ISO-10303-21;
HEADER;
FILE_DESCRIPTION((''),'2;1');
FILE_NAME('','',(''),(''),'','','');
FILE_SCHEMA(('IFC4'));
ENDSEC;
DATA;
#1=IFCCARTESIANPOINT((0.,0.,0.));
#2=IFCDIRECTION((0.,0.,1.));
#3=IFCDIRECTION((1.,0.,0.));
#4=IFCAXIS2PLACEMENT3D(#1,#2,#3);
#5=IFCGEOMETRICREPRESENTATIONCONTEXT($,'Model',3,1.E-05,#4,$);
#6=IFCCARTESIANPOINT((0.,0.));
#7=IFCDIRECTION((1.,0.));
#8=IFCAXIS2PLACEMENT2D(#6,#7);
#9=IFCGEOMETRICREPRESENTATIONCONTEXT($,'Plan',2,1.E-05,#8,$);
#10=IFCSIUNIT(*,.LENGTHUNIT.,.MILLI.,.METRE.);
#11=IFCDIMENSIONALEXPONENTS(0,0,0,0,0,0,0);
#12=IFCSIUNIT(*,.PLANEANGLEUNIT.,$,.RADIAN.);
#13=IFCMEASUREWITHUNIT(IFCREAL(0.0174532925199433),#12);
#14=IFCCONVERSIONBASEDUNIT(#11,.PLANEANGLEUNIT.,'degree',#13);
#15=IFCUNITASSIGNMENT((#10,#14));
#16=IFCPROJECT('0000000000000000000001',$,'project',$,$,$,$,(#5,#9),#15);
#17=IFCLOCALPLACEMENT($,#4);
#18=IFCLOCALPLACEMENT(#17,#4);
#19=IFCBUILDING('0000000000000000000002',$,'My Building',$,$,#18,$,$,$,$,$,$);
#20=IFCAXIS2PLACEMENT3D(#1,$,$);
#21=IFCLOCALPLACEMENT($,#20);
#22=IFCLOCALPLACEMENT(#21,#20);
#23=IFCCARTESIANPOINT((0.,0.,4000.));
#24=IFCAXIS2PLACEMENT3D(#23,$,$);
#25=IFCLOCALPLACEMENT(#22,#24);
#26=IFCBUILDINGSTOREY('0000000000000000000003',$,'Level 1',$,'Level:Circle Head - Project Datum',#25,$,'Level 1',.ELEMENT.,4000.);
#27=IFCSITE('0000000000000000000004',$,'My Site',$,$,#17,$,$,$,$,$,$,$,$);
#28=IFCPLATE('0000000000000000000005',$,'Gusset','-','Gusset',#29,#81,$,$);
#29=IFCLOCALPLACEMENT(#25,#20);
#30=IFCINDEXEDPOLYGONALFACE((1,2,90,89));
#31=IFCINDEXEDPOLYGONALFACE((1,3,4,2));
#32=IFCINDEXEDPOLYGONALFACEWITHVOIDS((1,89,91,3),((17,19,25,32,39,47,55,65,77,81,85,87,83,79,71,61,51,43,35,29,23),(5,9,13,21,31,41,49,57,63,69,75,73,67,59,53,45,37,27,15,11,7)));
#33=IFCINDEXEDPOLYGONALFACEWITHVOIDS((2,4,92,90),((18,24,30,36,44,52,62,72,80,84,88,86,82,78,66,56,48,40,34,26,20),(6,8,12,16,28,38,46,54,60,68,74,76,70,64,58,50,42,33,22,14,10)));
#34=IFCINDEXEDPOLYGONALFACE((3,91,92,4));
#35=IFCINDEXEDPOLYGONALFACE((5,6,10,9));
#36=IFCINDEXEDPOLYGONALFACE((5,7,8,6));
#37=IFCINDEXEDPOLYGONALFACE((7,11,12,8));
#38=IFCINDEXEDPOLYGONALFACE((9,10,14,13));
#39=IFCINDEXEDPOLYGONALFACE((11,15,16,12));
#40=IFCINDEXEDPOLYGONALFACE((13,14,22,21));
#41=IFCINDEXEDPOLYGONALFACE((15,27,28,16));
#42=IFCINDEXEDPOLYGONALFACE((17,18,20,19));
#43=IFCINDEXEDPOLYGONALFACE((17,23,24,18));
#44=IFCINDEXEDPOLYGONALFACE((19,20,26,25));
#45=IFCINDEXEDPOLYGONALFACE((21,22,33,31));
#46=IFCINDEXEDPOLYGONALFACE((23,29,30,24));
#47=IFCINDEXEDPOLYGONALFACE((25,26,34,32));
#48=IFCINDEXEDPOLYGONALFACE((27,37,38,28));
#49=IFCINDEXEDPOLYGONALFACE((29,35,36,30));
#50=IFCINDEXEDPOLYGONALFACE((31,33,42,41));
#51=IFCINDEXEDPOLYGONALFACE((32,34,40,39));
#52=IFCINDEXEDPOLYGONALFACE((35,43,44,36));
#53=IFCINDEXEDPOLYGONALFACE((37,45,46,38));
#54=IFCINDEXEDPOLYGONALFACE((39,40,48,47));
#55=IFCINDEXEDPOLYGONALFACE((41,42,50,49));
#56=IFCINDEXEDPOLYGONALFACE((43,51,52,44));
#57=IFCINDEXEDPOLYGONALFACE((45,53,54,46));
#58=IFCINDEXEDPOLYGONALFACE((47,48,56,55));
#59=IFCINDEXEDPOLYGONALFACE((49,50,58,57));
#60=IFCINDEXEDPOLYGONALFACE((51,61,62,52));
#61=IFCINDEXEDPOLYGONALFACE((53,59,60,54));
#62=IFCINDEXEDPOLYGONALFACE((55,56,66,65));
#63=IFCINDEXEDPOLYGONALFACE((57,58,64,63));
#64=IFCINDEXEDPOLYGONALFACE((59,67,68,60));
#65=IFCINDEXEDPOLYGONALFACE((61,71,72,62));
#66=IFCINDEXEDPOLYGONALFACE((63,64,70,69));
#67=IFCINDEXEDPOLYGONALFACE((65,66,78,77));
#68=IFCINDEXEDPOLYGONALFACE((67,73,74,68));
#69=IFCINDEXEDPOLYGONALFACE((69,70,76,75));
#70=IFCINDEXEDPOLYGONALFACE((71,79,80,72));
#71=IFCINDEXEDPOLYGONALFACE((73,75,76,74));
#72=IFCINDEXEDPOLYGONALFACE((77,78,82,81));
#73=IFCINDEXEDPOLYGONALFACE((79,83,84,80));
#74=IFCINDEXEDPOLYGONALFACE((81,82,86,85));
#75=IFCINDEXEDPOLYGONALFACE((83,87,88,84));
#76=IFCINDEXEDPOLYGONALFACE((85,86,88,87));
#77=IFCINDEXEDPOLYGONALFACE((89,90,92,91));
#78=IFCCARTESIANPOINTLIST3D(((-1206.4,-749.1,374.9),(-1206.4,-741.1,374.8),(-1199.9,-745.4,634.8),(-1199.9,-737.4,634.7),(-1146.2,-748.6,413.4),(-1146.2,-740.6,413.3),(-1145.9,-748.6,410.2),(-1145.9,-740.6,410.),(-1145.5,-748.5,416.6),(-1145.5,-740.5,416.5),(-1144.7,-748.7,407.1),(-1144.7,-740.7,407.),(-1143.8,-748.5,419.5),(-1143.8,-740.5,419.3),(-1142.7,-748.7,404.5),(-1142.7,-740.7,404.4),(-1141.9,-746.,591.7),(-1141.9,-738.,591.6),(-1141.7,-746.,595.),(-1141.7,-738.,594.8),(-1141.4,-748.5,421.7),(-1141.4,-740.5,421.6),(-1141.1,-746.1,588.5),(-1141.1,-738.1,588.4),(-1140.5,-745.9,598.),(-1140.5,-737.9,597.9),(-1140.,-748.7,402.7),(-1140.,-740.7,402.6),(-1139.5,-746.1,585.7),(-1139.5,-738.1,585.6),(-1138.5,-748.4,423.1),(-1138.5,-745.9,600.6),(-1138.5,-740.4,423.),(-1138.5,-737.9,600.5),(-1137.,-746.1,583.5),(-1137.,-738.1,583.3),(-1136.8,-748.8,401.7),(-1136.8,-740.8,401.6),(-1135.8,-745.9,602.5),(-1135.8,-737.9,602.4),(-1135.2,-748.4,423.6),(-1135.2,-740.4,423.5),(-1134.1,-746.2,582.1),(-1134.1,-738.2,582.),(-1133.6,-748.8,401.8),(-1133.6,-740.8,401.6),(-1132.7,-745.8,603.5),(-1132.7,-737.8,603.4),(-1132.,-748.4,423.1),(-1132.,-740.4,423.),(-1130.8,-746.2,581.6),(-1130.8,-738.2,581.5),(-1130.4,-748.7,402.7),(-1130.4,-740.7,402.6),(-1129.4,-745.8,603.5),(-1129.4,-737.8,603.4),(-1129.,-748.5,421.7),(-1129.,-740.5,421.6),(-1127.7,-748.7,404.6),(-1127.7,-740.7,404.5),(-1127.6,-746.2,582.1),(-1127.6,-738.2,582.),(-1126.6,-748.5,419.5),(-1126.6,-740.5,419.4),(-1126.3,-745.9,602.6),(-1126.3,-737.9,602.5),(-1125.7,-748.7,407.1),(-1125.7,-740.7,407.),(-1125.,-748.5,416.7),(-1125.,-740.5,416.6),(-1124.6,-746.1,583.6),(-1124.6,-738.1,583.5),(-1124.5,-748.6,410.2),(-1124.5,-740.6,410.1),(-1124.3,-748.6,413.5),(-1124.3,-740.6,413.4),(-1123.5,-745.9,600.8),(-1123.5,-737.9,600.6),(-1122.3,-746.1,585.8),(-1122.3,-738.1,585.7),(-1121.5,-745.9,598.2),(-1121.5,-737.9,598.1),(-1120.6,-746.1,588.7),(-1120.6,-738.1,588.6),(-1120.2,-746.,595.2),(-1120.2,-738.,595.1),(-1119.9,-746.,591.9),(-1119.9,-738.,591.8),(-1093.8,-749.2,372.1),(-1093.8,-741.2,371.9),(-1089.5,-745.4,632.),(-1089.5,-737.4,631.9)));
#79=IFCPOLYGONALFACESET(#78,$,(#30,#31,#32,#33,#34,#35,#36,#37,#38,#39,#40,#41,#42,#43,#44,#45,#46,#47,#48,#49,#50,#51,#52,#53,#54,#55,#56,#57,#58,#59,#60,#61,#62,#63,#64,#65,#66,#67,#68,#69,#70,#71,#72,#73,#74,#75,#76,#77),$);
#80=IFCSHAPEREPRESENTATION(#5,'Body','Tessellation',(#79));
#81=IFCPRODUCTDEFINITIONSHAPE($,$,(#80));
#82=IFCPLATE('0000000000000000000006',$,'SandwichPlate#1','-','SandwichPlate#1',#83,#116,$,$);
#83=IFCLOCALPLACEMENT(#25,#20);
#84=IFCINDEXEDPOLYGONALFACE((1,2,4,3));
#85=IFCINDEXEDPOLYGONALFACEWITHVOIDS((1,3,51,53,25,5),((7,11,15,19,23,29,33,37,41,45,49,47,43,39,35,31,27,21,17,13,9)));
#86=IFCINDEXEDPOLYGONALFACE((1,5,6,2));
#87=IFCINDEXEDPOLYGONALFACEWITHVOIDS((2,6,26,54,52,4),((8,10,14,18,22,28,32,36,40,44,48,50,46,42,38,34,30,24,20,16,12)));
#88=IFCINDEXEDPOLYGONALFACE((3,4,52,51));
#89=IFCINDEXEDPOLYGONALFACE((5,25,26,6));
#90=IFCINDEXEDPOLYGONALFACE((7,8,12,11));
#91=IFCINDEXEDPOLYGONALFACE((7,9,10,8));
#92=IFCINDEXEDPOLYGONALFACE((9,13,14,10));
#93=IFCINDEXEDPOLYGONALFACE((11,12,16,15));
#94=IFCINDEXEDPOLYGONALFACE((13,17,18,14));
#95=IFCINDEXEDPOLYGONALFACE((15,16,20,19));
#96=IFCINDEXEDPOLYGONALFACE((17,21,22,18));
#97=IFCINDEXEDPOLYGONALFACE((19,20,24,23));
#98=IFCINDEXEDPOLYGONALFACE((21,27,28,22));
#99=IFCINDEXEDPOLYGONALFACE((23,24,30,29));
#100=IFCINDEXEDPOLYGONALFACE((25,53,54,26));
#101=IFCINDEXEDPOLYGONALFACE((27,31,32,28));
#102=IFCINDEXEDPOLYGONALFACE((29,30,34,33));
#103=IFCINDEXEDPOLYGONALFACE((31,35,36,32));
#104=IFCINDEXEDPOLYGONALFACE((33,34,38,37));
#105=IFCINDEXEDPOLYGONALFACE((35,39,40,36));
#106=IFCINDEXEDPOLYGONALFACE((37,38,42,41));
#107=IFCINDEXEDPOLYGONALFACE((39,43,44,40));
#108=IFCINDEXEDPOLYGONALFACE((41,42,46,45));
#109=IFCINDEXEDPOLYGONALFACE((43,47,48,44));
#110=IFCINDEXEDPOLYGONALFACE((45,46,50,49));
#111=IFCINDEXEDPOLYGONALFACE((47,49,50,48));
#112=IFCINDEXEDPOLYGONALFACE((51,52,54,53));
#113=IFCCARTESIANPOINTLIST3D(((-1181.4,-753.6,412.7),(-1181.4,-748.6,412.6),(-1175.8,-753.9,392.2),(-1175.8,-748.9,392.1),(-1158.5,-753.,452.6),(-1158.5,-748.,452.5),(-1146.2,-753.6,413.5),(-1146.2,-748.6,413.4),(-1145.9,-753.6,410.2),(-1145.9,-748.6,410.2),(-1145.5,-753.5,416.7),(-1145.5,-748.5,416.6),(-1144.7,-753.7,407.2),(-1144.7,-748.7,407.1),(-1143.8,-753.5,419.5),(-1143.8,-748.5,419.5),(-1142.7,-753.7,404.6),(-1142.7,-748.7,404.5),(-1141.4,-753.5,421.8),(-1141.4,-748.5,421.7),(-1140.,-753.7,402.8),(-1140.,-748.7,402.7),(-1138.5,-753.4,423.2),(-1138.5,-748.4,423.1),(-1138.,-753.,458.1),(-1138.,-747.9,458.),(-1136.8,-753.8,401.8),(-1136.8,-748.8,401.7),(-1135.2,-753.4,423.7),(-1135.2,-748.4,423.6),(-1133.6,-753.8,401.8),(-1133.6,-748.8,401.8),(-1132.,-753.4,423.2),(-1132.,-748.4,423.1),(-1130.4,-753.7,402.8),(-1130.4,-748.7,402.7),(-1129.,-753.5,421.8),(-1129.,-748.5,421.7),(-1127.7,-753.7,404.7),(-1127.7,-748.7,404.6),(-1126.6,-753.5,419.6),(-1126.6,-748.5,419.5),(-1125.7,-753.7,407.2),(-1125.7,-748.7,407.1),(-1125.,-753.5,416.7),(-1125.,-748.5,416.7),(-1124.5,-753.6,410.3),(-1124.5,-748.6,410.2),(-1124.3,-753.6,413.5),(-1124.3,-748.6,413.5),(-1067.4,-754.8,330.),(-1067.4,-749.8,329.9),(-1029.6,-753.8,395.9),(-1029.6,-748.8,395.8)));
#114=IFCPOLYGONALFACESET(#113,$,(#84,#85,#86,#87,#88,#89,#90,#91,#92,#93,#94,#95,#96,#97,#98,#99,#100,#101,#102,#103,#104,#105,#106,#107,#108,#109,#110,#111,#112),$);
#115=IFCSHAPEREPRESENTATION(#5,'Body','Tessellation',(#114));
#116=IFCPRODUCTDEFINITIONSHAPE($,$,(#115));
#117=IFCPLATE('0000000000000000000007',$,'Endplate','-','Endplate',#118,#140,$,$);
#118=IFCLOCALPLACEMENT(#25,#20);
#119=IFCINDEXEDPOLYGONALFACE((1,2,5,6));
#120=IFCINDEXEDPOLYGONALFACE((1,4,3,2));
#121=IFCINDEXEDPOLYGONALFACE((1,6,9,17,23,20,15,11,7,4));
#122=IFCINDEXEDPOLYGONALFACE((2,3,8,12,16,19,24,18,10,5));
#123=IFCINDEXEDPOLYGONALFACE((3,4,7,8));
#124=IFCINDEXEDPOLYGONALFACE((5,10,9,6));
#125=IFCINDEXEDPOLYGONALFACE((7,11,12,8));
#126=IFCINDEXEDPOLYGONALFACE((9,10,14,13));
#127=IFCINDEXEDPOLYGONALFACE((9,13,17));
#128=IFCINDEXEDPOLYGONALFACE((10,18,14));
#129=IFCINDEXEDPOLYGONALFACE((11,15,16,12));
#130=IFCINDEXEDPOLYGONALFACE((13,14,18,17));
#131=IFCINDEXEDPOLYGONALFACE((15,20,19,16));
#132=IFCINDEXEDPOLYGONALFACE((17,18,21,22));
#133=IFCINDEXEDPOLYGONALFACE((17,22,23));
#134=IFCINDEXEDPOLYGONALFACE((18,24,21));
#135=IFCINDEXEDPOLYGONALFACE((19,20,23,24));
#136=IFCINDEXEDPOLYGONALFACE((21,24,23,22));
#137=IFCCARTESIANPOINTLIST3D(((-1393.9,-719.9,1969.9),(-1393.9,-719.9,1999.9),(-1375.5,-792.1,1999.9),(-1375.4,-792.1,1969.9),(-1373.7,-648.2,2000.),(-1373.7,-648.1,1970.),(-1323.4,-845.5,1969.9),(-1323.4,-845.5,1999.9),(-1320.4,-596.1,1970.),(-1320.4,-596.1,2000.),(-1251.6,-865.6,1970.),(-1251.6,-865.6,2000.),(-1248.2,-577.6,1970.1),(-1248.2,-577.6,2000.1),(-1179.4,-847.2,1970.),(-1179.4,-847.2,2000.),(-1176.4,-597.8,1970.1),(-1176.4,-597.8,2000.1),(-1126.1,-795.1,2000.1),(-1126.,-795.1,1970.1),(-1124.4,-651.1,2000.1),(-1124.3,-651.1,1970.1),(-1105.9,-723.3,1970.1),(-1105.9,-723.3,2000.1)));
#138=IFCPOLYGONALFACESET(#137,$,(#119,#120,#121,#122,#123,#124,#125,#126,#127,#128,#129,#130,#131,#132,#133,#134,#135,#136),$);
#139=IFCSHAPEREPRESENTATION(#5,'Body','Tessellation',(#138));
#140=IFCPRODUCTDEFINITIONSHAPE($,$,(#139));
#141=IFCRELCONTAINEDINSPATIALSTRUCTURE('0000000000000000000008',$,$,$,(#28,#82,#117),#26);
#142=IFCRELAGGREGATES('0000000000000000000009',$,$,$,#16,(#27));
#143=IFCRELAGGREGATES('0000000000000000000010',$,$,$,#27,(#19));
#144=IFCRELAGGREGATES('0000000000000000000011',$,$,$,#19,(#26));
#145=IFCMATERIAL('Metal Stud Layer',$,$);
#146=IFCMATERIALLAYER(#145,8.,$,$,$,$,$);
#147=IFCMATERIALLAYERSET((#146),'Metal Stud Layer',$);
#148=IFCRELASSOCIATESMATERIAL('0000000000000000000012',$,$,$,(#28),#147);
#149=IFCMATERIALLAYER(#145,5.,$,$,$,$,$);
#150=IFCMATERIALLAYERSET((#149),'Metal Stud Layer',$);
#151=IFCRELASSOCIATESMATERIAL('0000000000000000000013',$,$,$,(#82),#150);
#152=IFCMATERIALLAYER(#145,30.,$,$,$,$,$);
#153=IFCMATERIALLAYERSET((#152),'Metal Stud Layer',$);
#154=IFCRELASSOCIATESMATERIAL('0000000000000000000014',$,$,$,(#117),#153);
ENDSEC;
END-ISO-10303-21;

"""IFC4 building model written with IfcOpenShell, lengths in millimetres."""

from ifc_helpers import new_model, entity, si_unit, converted_unit, point, frame, frame_2d, origin, origin_with_axes, origin_2d_with_axis, place, context, project, spatial, polyline, circle_curve, line_curve, trimmed, segment, composite_curve, circle, outline, extrude, material, layer, layer_set, element, save


model = new_model("IFC4")

# Units and contexts
model_context = context("Model", 3, precision=1e-05, world=origin_with_axes())
plan_context = context("Plan", 2, precision=1e-05, world=origin_2d_with_axis())
ifc_project = project(units=[si_unit("LENGTHUNIT", "METRE", prefix="MILLI"), converted_unit("PLANEANGLEUNIT", "degree", entity("IfcReal", 0.0174532925199433), si_unit("PLANEANGLEUNIT", "RADIAN"), dimensions=[0, 0, 0, 0, 0, 0, 0])], contexts=[model_context, plan_context])

# Site, building, storey
site_placement = place(None, origin_with_axes())
site = spatial("IfcSite", under=ifc_project, at=site_placement, Name="My Site")
building_placement = place(site_placement, origin_with_axes())
building = spatial("IfcBuilding", under=site, at=building_placement, Name="My Building")
placement_1 = place(None, origin())
placement_2 = place(placement_1, origin())
storey_placement = place(placement_2, frame((0.0, 0.0, 4000.0)))
storey = spatial("IfcBuildingStorey", under=building, at=storey_placement, Name="Level 1", ObjectType="Level:Circle Head - Project Datum", LongName="Level 1", CompositionType="ELEMENT", Elevation=4000.0)

# Plates, openings
ifc_material_1 = material(Name="Metal Stud Layer")
ifc_layer_1 = layer(ifc_material_1, 5.0)
ifc_layer_set_1 = layer_set([ifc_layer_1], Name="Metal Stud Layer")
ifc_layer_2 = layer(ifc_material_1, 8.0)
ifc_layer_set_2 = layer_set([ifc_layer_2], Name="Metal Stud Layer")
plate_1_placement = place(storey_placement, frame((-1197.6, -737.4, 634.9), z_axis=(0.0, -0.999896, 0.014432), x_axis=(-0.02499, -0.014428, -0.999584)))
plate_1 = element("IfcPlate", 1, at=plate_1_placement, inside=storey, material=ifc_layer_set_2, Name="Gusset", Description="-", ObjectType="Gusset", context=model_context, shape_type="SweptSolid", body=[
    extrude(outline(polyline([(0.3, -2.3), (260.3, -2.3), (260.3, 110.4), (0.3, 108.2), (0.3, -2.3)])), origin_with_axes(), (0.0, 0.0, 1.0), 8.0),
])
opening_1_placement = place(plate_1_placement, frame((40.7, 67.8, 8.5), z_axis=(0.0, 0.0, -1.0), x_axis=(-0.530264, 0.847833, 0.0)))
element("IfcOpeningElement", 2, at=opening_1_placement, cuts=plate_1, ObjectType="Opening", context=model_context, shape_type="SweptSolid", body=[
    extrude(circle(Radius=11.0, at=origin_2d_with_axis()), origin(), (0.0, 0.0, 1.0), 9.0),
])
opening_2_placement = place(plate_1_placement, frame((220.8, 68.0, 8.5), z_axis=(0.0, 0.0, -1.0), x_axis=(0.476138, 0.879371, 0.0)))
element("IfcOpeningElement", 3, at=opening_2_placement, cuts=plate_1, ObjectType="Opening", context=model_context, shape_type="SweptSolid", body=[
    extrude(circle(Radius=11.0, at=origin_2d_with_axis()), origin(), (0.0, 0.0, 1.0), 9.0),
])
plate_2_placement = place(storey_placement, frame((-1188.8, -753.8, 399.7), z_axis=(0.0, 0.999896, -0.014432), x_axis=(0.497964, 0.012516, 0.867107)))
plate_2 = element("IfcPlate", 4, at=plate_2_placement, inside=storey, material=ifc_layer_set_1, Name="SandwichPlate#1", Description="-", ObjectType="SandwichPlate#1", context=model_context, shape_type="SweptSolid", body=[
    extrude(outline(polyline([(0.0, 0.0), (76.0, 0.0), (76.0, 140.0), (0.0, 140.0), (0.0, 0.0)])), origin_with_axes(), (0.0, 0.0, 1.0), 5.0),
])
opening_3_placement = place(plate_2_placement, frame((38.0, 40.0, -0.5), z_axis=(0.0, 0.0, 1.0), x_axis=(0.0, 1.0, 0.0)))
element("IfcOpeningElement", 5, at=opening_3_placement, cuts=plate_2, ObjectType="Opening", context=model_context, shape_type="SweptSolid", body=[
    extrude(circle(Radius=11.0, at=origin_2d_with_axis()), origin(), (0.0, 0.0, 1.0), 6.0),
])
opening_4_placement = place(plate_2_placement, frame((0.0, 0.0, 0.0), z_axis=(0.0, 0.0, 1.0), x_axis=(1.0, 0.0, 0.0)))
element("IfcOpeningElement", 6, at=opening_4_placement, cuts=plate_2, ObjectType="Opening", context=model_context, shape_type="SweptSolid", body=[
    extrude(outline(polyline([(0.0, 0.0), (15.0, 0.0), (0.0, 15.0), (0.0, 0.0)])), origin(), (0.0, 0.0, 1.0), 5.0),
])
opening_5_placement = place(plate_2_placement, frame((0.0, 0.0, 0.0), z_axis=(0.0, 0.0, 1.0), x_axis=(1.0, 0.0, 0.0)))
element("IfcOpeningElement", 7, at=opening_5_placement, cuts=plate_2, ObjectType="Opening", context=model_context, shape_type="SweptSolid", body=[
    extrude(outline(polyline([(76.0, 0.0), (76.0, 15.0), (61.0, 0.0), (76.0, 0.0)])), origin(), (0.0, 0.0, 1.0), 5.0),
])
ifc_layer_3 = layer(ifc_material_1, 30.0)
ifc_layer_set_3 = layer_set([ifc_layer_3], Name="Metal Stud Layer")
plate_3_placement = place(storey_placement, frame((-1179.4, -847.2, 1970.0), z_axis=(-0.000702, -0.000406, 1.0), x_axis=(0.871905, 0.489674, 0.000811)))
plate_3 = element("IfcPlate", 8, at=plate_3_placement, inside=storey, material=ifc_layer_set_3, Name="Endplate", Description="-", ObjectType="Endplate", context=model_context, shape_type="SweptSolid", body=[
    extrude(outline(polyline([(144.0, 0.0), (144.0, 288.0), (-144.0, 288.0), (-144.0, 0.0), (144.0, 0.0)])), origin_with_axes(), (0.0, 0.0, 1.0), 30.0),
])
opening_6_placement = place(plate_3_placement, frame((0.0, 0.0, 0.0), z_axis=(0.0, 0.0, 1.0), x_axis=(1.0, 0.0, 0.0)))
element("IfcOpeningElement", 9, at=opening_6_placement, cuts=plate_3, ObjectType="Opening", context=model_context, shape_type="SweptSolid", body=[
    extrude(outline(composite_curve([segment(trimmed(line_curve((-144.0, 0.0), (1.0, 0.0), 144.0), [point((-144.0, 0.0))], [point((0.0, 0.0))], True, "CARTESIAN"), True, "CONTINUOUS"), segment(trimmed(circle_curve(frame_2d((0.0, 144.0), x_axis=(-1.0, 0.0)), 144.0), [point((0.0, 0.0))], [point((-144.0, 144.0))], False, "CARTESIAN"), True, "CONTINUOUS"), segment(trimmed(line_curve((-144.0, 144.0), (0.0, -1.0), 144.0), [point((-144.0, 144.0))], [point((-144.0, 0.0))], True, "CARTESIAN"), True, "CONTINUOUS")], self_intersect=False)), origin(), (0.0, 0.0, 1.0), 30.0),
])
opening_7_placement = place(plate_3_placement, frame((0.0, 0.0, 0.0), z_axis=(0.0, 0.0, 1.0), x_axis=(1.0, 0.0, 0.0)))
element("IfcOpeningElement", 10, at=opening_7_placement, cuts=plate_3, ObjectType="Opening", context=model_context, shape_type="SweptSolid", body=[
    extrude(outline(composite_curve([segment(trimmed(line_curve((144.0, 288.0), (-1.0, 0.0), 144.0), [point((144.0, 288.0))], [point((0.0, 288.0))], True, "CARTESIAN"), True, "CONTINUOUS"), segment(trimmed(circle_curve(frame_2d((0.0, 144.0), x_axis=(-1.0, 0.0)), 144.0), [point((0.0, 288.0))], [point((144.0, 144.0))], False, "CARTESIAN"), True, "CONTINUOUS"), segment(trimmed(line_curve((144.0, 144.0), (0.0, 1.0), 144.0), [point((144.0, 144.0))], [point((144.0, 288.0))], True, "CARTESIAN"), True, "CONTINUOUS")], self_intersect=False)), origin(), (0.0, 0.0, 1.0), 30.0),
])
opening_8_placement = place(plate_3_placement, frame((0.0, 0.0, 0.0), z_axis=(0.0, 0.0, 1.0), x_axis=(1.0, 0.0, 0.0)))
element("IfcOpeningElement", 11, at=opening_8_placement, cuts=plate_3, ObjectType="Opening", context=model_context, shape_type="SweptSolid", body=[
    extrude(outline(composite_curve([segment(trimmed(line_curve((-144.0, 288.0), (0.0, -1.0), 144.0), [point((-144.0, 288.0))], [point((-144.0, 144.0))], True, "CARTESIAN"), True, "CONTINUOUS"), segment(trimmed(circle_curve(frame_2d((0.0, 144.0), x_axis=(-1.0, 0.0)), 144.0), [point((-144.0, 144.0))], [point((0.0, 288.0))], False, "CARTESIAN"), True, "CONTINUOUS"), segment(trimmed(line_curve((0.0, 288.0), (-1.0, 0.0), 144.0), [point((0.0, 288.0))], [point((-144.0, 288.0))], True, "CARTESIAN"), True, "CONTINUOUS")], self_intersect=False)), origin(), (0.0, 0.0, 1.0), 30.0),
])
opening_9_placement = place(plate_3_placement, frame((0.0, 0.0, 0.0), z_axis=(0.0, 0.0, 1.0), x_axis=(1.0, 0.0, 0.0)))
element("IfcOpeningElement", 12, at=opening_9_placement, cuts=plate_3, ObjectType="Opening", context=model_context, shape_type="SweptSolid", body=[
    extrude(outline(composite_curve([segment(trimmed(line_curve((144.0, 0.0), (0.0, 1.0), 144.0), [point((144.0, 0.0))], [point((144.0, 144.0))], True, "CARTESIAN"), True, "CONTINUOUS"), segment(trimmed(circle_curve(frame_2d((0.0, 144.0), x_axis=(-1.0, 0.0)), 144.0), [point((144.0, 144.0))], [point((0.0, 0.0))], False, "CARTESIAN"), True, "CONTINUOUS"), segment(trimmed(line_curve((0.0, 0.0), (1.0, 0.0), 144.0), [point((0.0, 0.0))], [point((144.0, 0.0))], True, "CARTESIAN"), True, "CONTINUOUS")], self_intersect=False)), origin(), (0.0, 0.0, 1.0), 30.0),
])

save(model, "model.ifc")
